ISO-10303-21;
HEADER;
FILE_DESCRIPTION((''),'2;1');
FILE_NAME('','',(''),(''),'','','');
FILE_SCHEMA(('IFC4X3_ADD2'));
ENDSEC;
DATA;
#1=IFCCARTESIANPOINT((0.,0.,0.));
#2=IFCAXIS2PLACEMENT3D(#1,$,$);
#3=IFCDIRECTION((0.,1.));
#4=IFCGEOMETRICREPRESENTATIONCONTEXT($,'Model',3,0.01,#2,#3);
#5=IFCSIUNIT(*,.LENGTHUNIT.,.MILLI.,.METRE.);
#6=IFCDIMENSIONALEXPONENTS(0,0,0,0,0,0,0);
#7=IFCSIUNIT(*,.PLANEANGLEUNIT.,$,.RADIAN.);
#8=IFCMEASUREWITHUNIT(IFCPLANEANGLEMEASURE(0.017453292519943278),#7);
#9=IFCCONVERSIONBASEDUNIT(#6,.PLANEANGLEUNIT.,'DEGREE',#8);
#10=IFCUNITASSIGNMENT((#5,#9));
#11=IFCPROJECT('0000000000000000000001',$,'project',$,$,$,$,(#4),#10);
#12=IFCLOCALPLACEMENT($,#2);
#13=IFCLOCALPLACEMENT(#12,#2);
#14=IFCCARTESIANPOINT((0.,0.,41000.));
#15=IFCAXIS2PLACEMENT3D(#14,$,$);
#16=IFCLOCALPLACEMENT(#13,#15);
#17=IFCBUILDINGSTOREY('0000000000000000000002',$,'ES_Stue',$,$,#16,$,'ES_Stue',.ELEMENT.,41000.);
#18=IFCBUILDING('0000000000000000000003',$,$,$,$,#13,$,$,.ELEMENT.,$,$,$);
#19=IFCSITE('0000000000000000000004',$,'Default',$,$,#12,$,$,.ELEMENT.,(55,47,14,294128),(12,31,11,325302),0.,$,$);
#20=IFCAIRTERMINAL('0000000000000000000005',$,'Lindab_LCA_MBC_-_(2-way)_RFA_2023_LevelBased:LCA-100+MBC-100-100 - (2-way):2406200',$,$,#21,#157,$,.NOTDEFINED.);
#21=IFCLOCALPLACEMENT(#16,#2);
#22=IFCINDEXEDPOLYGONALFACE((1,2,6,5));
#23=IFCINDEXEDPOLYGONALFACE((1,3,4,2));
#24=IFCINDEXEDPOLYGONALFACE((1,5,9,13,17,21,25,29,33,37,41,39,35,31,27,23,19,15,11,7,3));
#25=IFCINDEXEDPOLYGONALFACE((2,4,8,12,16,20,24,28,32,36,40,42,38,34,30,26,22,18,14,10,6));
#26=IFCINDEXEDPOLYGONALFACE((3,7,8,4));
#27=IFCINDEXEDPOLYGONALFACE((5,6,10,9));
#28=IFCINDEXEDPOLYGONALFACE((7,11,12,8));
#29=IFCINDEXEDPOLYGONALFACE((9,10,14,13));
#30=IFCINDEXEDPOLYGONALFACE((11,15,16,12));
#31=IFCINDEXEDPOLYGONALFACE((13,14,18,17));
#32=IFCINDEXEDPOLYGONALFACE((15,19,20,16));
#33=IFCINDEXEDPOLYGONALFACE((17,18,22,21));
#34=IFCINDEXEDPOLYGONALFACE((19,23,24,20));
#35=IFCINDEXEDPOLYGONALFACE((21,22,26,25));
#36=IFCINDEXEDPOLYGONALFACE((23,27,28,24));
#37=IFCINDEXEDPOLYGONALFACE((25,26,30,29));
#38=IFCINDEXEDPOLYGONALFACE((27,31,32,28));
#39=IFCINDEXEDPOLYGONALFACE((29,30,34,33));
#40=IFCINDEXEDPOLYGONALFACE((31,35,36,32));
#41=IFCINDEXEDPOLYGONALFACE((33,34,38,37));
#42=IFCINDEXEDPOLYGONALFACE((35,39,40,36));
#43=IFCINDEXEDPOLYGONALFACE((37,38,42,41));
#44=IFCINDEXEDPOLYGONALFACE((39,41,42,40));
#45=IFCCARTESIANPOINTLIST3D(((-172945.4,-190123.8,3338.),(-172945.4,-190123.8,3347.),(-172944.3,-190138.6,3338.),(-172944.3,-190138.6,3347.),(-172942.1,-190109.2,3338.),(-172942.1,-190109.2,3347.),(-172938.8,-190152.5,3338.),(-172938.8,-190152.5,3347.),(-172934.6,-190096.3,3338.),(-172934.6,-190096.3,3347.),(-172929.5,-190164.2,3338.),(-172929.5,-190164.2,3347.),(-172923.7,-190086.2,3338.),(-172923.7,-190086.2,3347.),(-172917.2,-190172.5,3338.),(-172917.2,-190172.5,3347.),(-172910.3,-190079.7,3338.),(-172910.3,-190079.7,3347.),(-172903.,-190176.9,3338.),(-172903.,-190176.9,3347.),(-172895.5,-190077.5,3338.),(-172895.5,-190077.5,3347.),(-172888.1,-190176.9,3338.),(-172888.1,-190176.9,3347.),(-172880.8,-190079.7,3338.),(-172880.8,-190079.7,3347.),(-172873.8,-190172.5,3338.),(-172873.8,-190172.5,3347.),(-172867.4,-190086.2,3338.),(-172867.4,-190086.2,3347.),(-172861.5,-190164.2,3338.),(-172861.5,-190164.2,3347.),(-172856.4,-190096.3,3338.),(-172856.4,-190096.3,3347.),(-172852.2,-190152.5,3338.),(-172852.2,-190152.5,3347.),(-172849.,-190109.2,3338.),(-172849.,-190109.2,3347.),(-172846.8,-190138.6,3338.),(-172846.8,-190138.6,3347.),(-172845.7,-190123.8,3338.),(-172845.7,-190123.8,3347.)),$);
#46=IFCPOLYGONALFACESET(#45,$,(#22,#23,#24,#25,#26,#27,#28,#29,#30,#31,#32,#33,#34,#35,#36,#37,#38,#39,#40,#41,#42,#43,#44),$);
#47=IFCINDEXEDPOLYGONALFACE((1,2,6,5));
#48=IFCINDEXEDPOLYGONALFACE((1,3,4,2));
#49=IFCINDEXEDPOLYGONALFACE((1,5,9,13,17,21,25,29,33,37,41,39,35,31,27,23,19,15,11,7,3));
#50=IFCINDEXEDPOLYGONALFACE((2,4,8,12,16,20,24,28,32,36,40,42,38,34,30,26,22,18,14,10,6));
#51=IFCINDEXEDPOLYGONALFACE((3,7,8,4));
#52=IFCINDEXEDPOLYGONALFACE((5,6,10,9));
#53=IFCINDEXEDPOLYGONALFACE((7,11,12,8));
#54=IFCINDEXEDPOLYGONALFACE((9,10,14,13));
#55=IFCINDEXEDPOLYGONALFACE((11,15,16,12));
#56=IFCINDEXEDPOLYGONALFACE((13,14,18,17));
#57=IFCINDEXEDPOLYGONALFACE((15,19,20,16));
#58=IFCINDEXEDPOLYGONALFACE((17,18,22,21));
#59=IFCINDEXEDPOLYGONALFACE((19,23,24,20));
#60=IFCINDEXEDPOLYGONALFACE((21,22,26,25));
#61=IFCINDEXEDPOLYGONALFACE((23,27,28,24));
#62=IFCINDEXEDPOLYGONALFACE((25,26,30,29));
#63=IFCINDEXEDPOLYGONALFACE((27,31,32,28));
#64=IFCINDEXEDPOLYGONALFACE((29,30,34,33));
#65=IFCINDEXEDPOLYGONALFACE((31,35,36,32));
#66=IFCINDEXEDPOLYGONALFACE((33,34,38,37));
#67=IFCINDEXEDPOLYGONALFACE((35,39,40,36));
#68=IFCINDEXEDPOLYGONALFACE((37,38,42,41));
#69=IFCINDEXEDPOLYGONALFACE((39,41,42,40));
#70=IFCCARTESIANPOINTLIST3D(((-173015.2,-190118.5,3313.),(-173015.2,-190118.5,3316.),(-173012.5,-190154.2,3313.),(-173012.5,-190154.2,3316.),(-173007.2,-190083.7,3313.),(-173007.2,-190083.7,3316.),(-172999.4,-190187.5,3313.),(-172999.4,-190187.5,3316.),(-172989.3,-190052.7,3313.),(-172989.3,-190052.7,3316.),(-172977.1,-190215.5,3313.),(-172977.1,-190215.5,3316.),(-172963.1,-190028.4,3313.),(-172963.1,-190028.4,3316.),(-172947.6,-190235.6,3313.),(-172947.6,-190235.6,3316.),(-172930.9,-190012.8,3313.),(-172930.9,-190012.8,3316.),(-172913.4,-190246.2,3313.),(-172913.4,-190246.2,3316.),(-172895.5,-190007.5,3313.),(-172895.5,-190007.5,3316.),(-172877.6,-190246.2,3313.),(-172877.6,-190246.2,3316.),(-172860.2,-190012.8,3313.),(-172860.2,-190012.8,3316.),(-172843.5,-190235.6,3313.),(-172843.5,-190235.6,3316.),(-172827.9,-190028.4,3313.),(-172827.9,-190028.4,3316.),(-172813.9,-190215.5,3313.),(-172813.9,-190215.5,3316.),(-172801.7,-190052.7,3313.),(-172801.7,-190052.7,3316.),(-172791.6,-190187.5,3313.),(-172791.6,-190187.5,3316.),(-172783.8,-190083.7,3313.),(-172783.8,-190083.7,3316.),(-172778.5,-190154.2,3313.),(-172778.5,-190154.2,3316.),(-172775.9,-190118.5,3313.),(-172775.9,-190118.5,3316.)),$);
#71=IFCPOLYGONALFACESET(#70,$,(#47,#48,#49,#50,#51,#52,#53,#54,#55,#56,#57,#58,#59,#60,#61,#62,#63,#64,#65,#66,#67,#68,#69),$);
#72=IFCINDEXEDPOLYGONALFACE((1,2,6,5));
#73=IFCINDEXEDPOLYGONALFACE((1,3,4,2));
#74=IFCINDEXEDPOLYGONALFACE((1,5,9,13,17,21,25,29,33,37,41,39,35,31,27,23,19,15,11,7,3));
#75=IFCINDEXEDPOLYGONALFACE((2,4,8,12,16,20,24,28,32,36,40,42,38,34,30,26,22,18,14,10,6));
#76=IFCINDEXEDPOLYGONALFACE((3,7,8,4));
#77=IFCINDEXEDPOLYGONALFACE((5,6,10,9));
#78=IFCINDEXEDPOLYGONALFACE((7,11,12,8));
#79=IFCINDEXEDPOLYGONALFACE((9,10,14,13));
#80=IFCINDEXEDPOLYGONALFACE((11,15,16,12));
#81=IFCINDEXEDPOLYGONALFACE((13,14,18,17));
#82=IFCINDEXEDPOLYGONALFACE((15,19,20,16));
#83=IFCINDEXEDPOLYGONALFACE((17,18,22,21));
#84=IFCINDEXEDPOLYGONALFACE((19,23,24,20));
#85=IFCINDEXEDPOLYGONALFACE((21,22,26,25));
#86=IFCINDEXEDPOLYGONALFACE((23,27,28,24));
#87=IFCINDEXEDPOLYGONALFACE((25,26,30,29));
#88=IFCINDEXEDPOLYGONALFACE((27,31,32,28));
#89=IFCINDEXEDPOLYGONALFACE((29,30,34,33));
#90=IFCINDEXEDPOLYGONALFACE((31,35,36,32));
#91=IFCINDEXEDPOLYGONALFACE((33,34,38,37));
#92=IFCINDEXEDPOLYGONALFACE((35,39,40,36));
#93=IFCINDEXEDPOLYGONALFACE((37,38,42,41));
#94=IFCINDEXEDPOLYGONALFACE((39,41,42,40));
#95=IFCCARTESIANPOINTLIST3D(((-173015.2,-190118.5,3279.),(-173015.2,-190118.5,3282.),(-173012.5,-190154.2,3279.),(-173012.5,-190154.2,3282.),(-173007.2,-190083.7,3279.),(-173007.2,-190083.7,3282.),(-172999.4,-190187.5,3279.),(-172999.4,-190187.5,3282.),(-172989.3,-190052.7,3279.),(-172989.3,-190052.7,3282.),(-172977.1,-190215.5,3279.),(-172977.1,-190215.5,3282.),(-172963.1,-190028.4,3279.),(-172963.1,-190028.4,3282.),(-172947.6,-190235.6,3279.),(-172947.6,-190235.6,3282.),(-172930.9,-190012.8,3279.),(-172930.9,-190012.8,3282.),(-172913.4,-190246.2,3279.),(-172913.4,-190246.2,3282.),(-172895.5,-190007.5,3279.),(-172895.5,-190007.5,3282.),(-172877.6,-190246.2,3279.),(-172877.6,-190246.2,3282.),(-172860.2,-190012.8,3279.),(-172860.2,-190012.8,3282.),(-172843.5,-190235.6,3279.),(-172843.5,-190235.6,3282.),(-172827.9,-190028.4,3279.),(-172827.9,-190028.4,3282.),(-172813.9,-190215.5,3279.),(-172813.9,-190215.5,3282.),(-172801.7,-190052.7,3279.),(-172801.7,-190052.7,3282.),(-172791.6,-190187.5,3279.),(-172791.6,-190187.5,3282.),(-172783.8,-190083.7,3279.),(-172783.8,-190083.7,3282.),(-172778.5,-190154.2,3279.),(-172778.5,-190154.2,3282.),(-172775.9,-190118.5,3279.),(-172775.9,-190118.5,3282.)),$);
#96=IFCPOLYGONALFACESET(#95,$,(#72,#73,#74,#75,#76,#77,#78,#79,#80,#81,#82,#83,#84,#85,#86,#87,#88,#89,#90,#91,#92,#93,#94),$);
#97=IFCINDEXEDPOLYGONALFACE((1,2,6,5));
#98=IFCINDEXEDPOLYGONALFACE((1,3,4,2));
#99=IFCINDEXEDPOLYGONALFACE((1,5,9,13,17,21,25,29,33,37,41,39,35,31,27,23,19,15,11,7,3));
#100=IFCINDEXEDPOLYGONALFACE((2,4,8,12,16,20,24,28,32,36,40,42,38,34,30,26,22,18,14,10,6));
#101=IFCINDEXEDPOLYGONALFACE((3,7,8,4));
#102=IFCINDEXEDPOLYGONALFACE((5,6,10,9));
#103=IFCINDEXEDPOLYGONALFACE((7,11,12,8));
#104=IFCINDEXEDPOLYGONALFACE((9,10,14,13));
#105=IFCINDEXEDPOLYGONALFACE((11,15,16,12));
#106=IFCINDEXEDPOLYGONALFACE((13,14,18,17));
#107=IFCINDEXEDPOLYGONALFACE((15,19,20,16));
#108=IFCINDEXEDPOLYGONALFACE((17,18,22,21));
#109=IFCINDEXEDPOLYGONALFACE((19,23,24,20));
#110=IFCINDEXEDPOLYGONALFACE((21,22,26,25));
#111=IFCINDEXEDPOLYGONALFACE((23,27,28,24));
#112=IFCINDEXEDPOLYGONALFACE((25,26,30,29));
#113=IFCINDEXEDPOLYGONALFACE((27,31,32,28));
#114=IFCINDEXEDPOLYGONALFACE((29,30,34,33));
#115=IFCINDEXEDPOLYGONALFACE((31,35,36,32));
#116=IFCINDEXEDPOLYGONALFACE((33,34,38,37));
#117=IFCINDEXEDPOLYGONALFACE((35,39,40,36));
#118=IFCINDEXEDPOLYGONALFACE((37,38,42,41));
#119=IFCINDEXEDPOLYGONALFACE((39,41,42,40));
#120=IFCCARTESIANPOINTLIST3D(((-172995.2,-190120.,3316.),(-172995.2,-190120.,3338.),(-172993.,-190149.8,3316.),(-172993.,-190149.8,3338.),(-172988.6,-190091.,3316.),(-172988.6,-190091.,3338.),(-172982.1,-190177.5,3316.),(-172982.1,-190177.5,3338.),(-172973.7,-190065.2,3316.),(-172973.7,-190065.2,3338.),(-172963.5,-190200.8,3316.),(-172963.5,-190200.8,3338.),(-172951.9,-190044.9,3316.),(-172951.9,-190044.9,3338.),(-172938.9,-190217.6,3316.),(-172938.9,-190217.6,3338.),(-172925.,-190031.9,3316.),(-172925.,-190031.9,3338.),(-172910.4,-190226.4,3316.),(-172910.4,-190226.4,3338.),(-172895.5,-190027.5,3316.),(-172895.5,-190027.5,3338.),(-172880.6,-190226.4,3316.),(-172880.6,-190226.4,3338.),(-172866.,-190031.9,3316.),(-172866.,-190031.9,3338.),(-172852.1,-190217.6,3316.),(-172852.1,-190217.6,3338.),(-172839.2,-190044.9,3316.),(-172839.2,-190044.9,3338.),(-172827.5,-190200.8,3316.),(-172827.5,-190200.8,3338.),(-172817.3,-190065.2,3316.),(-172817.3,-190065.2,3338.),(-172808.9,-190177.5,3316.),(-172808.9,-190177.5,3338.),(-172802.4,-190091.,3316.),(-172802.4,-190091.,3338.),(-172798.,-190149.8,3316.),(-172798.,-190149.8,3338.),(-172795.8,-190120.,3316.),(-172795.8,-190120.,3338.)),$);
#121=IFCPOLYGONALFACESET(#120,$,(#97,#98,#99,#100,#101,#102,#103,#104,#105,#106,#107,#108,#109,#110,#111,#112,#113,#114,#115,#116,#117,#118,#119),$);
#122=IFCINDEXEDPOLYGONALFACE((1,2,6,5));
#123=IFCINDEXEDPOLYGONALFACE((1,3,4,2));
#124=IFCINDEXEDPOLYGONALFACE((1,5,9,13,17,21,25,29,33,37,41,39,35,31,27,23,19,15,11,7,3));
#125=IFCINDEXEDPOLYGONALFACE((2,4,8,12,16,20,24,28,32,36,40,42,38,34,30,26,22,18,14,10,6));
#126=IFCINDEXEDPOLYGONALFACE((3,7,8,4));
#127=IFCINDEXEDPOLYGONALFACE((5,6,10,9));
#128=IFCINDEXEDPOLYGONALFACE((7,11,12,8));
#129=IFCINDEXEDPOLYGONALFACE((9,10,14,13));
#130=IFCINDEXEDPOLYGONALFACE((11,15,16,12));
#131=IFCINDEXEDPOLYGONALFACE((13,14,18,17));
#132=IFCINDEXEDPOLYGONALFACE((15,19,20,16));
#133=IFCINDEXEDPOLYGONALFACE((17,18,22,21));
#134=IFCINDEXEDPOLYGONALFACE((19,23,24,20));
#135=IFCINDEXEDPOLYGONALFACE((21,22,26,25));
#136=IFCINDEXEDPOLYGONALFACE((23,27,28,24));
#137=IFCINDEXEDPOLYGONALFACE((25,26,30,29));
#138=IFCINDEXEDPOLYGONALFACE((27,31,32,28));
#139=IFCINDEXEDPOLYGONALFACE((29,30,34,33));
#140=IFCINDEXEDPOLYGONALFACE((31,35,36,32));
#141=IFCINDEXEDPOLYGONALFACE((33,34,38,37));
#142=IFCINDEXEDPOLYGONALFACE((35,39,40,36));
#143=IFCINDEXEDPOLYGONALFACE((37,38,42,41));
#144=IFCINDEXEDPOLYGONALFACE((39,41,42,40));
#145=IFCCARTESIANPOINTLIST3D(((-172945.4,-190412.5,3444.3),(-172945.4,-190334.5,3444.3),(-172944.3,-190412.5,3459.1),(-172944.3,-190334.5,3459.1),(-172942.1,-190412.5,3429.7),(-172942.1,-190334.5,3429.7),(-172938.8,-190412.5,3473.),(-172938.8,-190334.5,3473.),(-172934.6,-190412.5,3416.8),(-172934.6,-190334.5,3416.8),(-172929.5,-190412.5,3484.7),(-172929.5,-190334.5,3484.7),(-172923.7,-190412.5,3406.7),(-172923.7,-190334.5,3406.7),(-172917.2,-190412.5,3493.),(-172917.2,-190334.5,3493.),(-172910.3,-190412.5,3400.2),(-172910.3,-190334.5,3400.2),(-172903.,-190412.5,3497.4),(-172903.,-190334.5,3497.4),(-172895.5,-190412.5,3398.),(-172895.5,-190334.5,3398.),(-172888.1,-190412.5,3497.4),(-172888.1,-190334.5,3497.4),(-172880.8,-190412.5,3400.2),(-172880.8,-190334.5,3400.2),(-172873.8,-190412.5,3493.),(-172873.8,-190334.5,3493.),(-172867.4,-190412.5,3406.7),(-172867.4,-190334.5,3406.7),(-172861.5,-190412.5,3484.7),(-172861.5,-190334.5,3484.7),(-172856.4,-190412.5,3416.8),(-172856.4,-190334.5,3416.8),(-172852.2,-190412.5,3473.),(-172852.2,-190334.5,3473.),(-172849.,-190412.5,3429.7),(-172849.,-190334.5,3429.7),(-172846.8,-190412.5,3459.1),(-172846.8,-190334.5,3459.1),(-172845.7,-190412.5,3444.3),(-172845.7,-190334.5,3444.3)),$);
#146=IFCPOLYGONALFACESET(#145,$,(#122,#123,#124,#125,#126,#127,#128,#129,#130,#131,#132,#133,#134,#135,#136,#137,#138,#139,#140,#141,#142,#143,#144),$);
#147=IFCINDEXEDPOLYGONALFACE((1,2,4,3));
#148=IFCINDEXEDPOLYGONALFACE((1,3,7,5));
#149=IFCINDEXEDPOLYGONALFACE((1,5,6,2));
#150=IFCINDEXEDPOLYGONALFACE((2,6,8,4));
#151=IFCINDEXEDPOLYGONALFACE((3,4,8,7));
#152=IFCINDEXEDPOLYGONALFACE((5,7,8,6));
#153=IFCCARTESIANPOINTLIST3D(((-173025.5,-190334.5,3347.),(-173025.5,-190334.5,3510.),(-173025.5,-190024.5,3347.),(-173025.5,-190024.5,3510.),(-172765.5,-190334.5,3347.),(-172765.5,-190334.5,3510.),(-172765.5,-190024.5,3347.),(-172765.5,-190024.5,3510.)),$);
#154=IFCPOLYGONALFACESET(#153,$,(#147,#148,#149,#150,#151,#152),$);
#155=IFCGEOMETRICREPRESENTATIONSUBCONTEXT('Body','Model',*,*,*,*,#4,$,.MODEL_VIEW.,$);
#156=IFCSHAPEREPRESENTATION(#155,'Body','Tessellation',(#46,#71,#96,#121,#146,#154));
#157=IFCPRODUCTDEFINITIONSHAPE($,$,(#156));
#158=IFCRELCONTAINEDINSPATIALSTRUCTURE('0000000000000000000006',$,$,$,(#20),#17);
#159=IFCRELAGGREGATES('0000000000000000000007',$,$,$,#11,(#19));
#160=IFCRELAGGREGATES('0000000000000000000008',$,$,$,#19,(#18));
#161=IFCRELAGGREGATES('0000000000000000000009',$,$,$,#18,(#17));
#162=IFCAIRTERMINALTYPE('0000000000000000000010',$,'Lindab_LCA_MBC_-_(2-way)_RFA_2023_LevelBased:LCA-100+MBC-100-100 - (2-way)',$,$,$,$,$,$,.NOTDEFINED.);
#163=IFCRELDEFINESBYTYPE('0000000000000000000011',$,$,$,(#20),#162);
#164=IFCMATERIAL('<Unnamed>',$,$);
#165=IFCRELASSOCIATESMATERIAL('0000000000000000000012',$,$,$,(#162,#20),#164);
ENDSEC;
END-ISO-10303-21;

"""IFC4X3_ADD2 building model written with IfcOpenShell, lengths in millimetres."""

from ifc_helpers import new_model, entity, si_unit, converted_unit, direction, frame, frame_2d, origin, origin_2d_with_axis, place, context, subcontext, project, spatial, rectangle, circle, extrude, source, transform, mapped, material, type_object, type_shapes, element, save


model = new_model("IFC4X3_ADD2")

# Units and contexts
model_context = context("Model", 3, precision=0.01, world=origin(), true_north=direction((0.0, 1.0)))
body_context = subcontext(model_context, "Body", "Model", "MODEL_VIEW")
ifc_project = project(units=[si_unit("LENGTHUNIT", "METRE", prefix="MILLI"), converted_unit("PLANEANGLEUNIT", "DEGREE", entity("IfcPlaneAngleMeasure", 0.017453292519943278), si_unit("PLANEANGLEUNIT", "RADIAN"), dimensions=[0, 0, 0, 0, 0, 0, 0])], contexts=[model_context])

# Site, building, storey
site_placement = place(None, origin())
site = spatial("IfcSite", under=ifc_project, at=site_placement, Name="Default", CompositionType="ELEMENT", RefLatitude=(55, 47, 14, 294128), RefLongitude=(12, 31, 11, 325302), RefElevation=0.0)
building_placement = place(site_placement, origin())
building = spatial("IfcBuilding", under=site, at=building_placement, CompositionType="ELEMENT")
storey_placement = place(building_placement, frame((0.0, 0.0, 41000.0)))
storey = spatial("IfcBuildingStorey", under=building, at=storey_placement, Name="ES_Stue", LongName="ES_Stue", CompositionType="ELEMENT", Elevation=41000.0)

# Air terminal
ifc_material_1 = material(Name="<Unnamed>")
air_terminal_type = type_object("IfcAirTerminalType", Name="Lindab_LCA_MBC_-_(2-way)_RFA_2023_LevelBased:LCA-100+MBC-100-100 - (2-way)", PredefinedType="NOTDEFINED", material=ifc_material_1)
shared_shape_1 = source(origin(), body_context, "Body", "SweptSolid", [
    extrude(circle(Radius=50.0, at=frame_2d((0.0, 0.0), x_axis=(1.0, 0.0))), frame((0.0, 0.0, 22.0)), (0.0, 0.0, 1.0), 9.0),
    extrude(circle(Radius=120.0, at=frame_2d((0.0, 0.0), x_axis=(1.0, 0.0))), frame((0.0, 0.0, -3.0)), (0.0, 0.0, 1.0), 3.0),
    extrude(circle(Radius=120.0, at=frame_2d((0.0, 0.0), x_axis=(1.0, 0.0))), frame((0.0, 0.0, -37.0)), (0.0, 0.0, 1.0), 3.0),
    extrude(circle(Radius=100.0, at=frame_2d((0.0, 0.0), x_axis=(1.0, 0.0))), origin(), (0.0, 0.0, 1.0), 22.0),
    extrude(circle(Radius=50.0, at=frame_2d((0.0, 0.0), x_axis=(1.0, 0.0))), frame((-285.0, 0.0, 132.0), z_axis=(1.0, 0.0, 0.0), x_axis=(0.0, 0.0, -1.0)), (0.0, 0.0, 1.0), 78.0),
    extrude(rectangle(XDim=260.0, YDim=310.0, at=origin_2d_with_axis()), frame((-52.0, 0.0, 31.0), z_axis=(0.0, 0.0, 1.0), x_axis=(0.0, -1.0, 0.0)), (0.0, 0.0, 1.0), 163.0),
])
type_shapes(air_terminal_type, [shared_shape_1])
for number, where, z_axis, x_axis, name in (
    (1, (-172895.5, -190127.5, 3316.0), (0.0, 0.0, 1.0), (0.0, 1.0, 0.0), "Lindab_LCA_MBC_-_(2-way)_RFA_2023_LevelBased:LCA-100+MBC-100-100 - (2-way):2406200"),
):
    element("IfcAirTerminal", number, at=place(storey_placement, frame(where, z_axis=z_axis, x_axis=x_axis)), inside=storey, type_object=air_terminal_type, material=ifc_material_1, Name=name, PredefinedType="NOTDEFINED", context=body_context, shape_type="MappedRepresentation", body=[
        mapped(shared_shape_1, transform((0.0, 0.0, 0.0), scale=1.0)),
    ])

save(model, "model.ifc")
